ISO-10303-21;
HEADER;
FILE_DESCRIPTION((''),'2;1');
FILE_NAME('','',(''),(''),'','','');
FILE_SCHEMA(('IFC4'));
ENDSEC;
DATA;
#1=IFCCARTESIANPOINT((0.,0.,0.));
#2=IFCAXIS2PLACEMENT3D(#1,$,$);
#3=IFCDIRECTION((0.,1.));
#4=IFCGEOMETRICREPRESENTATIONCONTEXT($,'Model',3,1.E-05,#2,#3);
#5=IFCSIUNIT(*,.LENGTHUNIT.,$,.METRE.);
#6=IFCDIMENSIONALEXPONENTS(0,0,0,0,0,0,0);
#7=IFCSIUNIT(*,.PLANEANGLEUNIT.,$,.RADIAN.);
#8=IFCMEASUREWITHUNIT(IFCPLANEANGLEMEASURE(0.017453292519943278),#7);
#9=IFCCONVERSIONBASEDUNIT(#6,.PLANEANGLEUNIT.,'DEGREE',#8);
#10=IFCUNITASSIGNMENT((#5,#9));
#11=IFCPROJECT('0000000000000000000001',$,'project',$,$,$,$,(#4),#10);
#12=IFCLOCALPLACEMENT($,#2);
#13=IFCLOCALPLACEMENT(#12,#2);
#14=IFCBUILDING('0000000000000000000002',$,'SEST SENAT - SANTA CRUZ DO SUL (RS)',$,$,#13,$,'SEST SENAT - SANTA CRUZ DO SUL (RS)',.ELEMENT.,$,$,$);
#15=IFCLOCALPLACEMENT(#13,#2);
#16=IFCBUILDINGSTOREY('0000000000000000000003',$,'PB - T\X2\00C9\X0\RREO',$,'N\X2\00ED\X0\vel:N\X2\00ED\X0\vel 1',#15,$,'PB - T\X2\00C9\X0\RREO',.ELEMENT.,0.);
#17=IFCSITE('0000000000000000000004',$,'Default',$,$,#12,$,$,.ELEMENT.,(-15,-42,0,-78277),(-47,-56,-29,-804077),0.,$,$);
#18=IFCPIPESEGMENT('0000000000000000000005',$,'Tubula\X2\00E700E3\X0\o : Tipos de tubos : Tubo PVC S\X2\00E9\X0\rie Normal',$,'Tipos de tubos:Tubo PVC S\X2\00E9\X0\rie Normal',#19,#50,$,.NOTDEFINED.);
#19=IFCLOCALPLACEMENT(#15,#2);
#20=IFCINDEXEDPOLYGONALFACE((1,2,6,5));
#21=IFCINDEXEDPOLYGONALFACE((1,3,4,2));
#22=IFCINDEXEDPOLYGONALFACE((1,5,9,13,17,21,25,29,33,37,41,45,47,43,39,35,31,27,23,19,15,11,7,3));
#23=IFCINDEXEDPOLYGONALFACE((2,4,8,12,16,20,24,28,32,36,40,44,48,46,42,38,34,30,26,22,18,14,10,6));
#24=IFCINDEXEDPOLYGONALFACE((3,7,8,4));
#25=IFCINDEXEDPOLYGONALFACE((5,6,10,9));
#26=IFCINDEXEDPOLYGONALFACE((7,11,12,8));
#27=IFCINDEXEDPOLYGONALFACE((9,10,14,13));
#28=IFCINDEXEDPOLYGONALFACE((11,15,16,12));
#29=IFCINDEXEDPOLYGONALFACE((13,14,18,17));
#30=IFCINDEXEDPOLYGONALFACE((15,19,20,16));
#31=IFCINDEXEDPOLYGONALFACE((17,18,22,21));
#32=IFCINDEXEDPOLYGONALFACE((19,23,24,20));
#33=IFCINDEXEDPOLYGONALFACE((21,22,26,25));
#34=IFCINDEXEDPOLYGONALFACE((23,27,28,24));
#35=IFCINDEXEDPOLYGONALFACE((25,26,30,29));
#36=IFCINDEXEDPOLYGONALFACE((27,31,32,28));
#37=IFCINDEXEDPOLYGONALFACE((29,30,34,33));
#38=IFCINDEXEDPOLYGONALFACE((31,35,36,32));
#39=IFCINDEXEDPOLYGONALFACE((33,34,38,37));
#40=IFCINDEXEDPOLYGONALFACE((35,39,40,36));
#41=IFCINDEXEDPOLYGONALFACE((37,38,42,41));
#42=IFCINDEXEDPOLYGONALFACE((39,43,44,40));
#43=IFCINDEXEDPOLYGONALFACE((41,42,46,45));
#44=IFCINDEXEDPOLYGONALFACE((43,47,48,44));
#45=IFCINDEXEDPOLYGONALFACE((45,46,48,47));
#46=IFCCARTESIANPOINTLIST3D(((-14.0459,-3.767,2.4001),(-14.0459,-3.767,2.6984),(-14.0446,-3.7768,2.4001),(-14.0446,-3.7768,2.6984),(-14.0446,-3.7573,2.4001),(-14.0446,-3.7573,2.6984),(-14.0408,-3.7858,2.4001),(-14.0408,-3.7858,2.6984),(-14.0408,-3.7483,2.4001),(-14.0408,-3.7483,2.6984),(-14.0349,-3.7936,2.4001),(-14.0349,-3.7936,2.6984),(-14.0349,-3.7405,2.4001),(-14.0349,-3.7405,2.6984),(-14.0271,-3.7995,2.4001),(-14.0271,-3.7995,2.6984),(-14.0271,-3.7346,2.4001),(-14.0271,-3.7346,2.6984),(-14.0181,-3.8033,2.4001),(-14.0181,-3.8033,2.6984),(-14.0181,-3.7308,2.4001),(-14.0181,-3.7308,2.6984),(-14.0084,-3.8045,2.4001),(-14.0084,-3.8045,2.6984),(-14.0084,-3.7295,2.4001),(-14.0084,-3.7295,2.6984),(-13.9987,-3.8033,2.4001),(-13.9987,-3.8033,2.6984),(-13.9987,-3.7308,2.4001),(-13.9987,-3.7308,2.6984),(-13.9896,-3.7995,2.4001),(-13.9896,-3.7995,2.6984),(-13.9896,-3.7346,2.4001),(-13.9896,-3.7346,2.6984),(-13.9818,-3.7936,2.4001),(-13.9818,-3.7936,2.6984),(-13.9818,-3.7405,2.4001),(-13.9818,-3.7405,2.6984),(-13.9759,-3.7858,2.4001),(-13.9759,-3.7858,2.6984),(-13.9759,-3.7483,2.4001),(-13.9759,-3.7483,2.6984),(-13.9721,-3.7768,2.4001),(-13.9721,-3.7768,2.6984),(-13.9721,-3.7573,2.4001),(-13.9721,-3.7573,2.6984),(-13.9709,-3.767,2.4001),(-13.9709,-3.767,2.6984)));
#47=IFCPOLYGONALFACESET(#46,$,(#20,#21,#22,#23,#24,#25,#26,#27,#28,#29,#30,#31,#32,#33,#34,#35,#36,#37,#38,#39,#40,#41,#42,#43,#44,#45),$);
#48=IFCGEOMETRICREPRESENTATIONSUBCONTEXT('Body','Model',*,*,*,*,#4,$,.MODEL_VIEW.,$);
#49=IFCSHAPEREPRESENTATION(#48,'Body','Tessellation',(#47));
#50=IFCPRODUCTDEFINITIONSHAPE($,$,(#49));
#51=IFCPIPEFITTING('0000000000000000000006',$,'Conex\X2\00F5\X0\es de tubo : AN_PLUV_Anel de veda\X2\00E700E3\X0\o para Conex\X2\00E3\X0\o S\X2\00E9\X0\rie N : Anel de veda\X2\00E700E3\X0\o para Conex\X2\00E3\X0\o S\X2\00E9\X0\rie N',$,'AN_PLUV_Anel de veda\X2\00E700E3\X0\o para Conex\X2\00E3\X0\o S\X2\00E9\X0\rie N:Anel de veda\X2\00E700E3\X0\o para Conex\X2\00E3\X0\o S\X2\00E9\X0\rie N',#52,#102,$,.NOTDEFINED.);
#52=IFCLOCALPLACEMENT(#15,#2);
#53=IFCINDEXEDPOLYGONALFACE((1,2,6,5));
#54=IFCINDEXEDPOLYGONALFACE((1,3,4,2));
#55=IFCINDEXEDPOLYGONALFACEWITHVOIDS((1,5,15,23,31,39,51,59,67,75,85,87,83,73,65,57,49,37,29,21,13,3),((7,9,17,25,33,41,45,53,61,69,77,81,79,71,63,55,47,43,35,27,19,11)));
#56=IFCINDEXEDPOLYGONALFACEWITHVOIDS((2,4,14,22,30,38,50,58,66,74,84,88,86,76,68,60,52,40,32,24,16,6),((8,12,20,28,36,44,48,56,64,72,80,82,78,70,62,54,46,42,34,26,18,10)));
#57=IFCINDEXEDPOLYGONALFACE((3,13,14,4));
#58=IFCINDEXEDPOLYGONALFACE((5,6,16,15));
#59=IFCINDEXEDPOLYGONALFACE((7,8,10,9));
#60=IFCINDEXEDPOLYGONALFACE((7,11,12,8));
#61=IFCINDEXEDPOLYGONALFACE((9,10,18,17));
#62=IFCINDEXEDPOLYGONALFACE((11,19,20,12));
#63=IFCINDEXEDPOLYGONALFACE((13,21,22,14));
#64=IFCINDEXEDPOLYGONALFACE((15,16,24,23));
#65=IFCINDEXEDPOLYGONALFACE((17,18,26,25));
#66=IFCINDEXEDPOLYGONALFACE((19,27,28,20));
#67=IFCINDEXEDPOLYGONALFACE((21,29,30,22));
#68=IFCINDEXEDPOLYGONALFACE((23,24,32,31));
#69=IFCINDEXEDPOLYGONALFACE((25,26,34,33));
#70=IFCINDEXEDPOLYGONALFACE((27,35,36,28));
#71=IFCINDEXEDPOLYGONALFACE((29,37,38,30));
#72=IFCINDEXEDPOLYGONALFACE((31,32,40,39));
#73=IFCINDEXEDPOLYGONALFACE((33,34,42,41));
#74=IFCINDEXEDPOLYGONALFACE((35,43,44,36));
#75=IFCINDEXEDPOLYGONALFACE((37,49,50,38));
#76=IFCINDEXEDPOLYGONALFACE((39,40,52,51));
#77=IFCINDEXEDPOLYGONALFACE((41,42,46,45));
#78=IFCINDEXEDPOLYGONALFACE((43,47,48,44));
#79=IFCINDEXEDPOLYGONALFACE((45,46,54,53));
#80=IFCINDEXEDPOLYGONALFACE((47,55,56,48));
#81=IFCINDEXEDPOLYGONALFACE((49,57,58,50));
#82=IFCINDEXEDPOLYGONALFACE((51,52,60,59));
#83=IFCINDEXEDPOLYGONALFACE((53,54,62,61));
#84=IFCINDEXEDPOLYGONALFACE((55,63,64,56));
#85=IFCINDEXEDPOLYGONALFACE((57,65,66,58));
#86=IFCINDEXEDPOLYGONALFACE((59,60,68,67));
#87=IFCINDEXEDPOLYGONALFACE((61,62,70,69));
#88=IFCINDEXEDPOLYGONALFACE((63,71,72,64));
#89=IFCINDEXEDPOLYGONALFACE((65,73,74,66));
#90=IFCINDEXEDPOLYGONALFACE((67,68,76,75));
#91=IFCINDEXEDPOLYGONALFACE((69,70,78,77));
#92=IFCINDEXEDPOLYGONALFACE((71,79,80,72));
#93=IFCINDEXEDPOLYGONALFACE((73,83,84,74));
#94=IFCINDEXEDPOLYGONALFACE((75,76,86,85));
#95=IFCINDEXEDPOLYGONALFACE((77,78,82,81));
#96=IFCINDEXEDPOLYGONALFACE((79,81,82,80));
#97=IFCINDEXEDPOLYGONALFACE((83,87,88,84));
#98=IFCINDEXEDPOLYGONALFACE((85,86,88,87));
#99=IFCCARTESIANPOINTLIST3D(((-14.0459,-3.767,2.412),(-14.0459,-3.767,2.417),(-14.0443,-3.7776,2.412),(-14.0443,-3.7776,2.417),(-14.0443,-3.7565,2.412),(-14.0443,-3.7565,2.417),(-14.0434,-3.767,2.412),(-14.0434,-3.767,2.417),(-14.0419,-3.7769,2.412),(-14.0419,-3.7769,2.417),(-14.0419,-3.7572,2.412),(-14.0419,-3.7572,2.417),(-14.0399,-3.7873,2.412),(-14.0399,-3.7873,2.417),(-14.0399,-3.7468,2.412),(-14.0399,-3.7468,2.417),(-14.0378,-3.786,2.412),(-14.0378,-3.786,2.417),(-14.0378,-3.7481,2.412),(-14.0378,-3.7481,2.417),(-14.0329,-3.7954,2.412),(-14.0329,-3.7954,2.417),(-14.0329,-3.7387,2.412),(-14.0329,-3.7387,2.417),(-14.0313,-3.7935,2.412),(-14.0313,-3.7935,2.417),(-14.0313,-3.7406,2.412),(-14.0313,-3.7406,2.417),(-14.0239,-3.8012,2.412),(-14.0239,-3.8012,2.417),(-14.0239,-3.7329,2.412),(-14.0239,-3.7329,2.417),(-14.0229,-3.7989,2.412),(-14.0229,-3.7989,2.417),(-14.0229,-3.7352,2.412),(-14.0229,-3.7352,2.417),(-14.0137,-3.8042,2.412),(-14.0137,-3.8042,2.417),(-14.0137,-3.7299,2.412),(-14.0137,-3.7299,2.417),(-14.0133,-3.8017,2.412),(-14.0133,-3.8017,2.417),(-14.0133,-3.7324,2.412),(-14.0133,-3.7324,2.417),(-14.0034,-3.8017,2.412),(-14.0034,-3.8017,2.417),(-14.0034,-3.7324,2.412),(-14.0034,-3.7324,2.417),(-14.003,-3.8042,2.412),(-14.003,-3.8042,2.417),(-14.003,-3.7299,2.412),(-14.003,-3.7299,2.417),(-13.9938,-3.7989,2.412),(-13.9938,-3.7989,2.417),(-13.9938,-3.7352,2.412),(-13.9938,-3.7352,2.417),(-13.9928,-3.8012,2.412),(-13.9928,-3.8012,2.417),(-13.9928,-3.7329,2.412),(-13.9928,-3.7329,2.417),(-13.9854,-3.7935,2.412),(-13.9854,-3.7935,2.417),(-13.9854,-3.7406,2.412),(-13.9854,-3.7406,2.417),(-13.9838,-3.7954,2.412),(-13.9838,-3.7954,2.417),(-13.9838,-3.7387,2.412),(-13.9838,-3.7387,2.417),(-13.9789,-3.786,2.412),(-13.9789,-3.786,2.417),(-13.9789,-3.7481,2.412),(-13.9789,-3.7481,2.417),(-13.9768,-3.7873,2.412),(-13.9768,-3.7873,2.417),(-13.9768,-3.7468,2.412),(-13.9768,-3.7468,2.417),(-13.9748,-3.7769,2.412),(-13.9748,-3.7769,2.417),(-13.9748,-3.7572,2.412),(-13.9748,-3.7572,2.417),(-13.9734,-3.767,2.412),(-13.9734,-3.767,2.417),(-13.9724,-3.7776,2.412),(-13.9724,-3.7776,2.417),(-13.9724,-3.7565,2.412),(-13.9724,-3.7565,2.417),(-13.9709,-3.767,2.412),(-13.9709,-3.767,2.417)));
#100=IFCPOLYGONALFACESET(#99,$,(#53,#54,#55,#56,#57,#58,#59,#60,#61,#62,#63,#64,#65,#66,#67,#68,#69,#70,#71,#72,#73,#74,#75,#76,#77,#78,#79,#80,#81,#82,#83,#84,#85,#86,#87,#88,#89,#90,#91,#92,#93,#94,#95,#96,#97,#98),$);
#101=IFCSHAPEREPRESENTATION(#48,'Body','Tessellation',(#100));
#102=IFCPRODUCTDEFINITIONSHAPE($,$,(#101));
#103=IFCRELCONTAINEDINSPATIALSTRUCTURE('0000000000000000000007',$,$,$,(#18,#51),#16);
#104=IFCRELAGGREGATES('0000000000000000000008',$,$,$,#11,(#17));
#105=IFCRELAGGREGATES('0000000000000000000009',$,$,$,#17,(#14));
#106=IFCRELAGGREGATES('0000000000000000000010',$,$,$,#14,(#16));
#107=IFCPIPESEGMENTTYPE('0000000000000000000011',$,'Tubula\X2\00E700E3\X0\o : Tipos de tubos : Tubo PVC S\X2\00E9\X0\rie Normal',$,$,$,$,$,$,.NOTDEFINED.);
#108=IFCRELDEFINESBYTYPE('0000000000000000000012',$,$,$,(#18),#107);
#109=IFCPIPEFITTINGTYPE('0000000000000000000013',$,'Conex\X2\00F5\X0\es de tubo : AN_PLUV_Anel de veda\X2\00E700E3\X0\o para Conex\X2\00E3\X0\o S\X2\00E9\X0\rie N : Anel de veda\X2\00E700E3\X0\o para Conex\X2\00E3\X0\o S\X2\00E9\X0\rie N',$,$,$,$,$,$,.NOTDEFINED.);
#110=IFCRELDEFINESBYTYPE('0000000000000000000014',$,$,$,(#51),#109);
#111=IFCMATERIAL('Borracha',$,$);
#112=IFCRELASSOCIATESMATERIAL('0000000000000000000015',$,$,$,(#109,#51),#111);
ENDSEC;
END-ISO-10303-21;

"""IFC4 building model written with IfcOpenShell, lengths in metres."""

from ifc_helpers import new_model, entity, si_unit, converted_unit, direction, frame, origin, place, context, subcontext, project, spatial, arc, indexed_curve, outline, extrude, source, transform, mapped, material, type_object, type_shapes, element, save


model = new_model("IFC4")

# Units and contexts
model_context = context("Model", 3, precision=1e-05, world=origin(), true_north=direction((0.0, 1.0)))
body_context = subcontext(model_context, "Body", "Model", "MODEL_VIEW")
ifc_project = project(units=[si_unit("LENGTHUNIT", "METRE"), converted_unit("PLANEANGLEUNIT", "DEGREE", entity("IfcPlaneAngleMeasure", 0.017453292519943278), si_unit("PLANEANGLEUNIT", "RADIAN"), dimensions=[0, 0, 0, 0, 0, 0, 0])], contexts=[model_context])

# Site, building, storey
site_placement = place(None, origin())
site = spatial("IfcSite", under=ifc_project, at=site_placement, Name="Default", CompositionType="ELEMENT", RefLatitude=(-15, -42, 0, -78277), RefLongitude=(-47, -56, -29, -804077), RefElevation=0.0)
building_placement = place(site_placement, origin())
building = spatial("IfcBuilding", under=site, at=building_placement, Name="SEST SENAT - SANTA CRUZ DO SUL (RS)", LongName="SEST SENAT - SANTA CRUZ DO SUL (RS)", CompositionType="ELEMENT")
storey_placement = place(building_placement, origin())
storey = spatial("IfcBuildingStorey", under=building, at=storey_placement, Name="PB - TÉRREO", ObjectType="Nível:Nível 1", LongName="PB - TÉRREO", CompositionType="ELEMENT", Elevation=0.0)

# Pipe segment
pipe_segment_type_1 = type_object("IfcPipeSegmentType", Name="Tubulação : Tipos de tubos : Tubo PVC Série Normal", PredefinedType="NOTDEFINED")
pipe_segment_1_placement = place(storey_placement, frame((-14.0475, -3.8061, 2.4001)))
element("IfcPipeSegment", 1, at=pipe_segment_1_placement, inside=storey, type_object=pipe_segment_type_1, Name="Tubulação : Tipos de tubos : Tubo PVC Série Normal", ObjectType="Tipos de tubos:Tubo PVC Série Normal", PredefinedType="NOTDEFINED", context=body_context, shape_type="SweptSolid", body=[
    extrude(outline(indexed_curve([(0.0375, 0.0), (0.0265, 0.0265), (0.0, 0.0375), (-0.0265, 0.0265), (-0.0375, 0.0), (-0.0265, -0.0265), (0.0, -0.0375), (0.0265, -0.0265)], segments=[arc(1, 2, 3), arc(3, 4, 5), arc(5, 6, 7), arc(7, 8, 1)], self_intersect=False)), frame((0.0391, 0.0391, 0.0), z_axis=(0.0, 0.0, 1.0), x_axis=(-1.0, 0.0, 0.0)), (0.0, 0.0, 1.0), 0.2983),
])

# Pipe fitting
ifc_material = material(Name="Borracha")
pipe_fitting_type = type_object("IfcPipeFittingType", Name="Conexões de tubo : AN_PLUV_Anel de vedação para Conexão Série N : Anel de vedação para Conexão Série N", PredefinedType="NOTDEFINED", material=ifc_material)
shared_shape = source(origin(), body_context, "Body", "SweptSolid", [
    extrude(outline(indexed_curve([(-0.0375, 0.0), (0.0, -0.0375), (0.0375, 0.0), (0.0, 0.0375)], segments=[arc(1, 2, 3), arc(3, 4, 1)], self_intersect=False), holes=[indexed_curve([(-0.035, 0.0), (0.0, 0.035), (0.035, 0.0), (0.0, -0.035)], segments=[arc(1, 2, 3), arc(3, 4, 1)], self_intersect=False)]), frame((0.0, 0.0, -0.005)), (0.0, 0.0, 1.0), 0.005),
])
type_shapes(pipe_fitting_type, [shared_shape])
pipe_fitting_placement = place(storey_placement, frame((-14.0084, -3.767, 2.412), z_axis=(0.0, 0.0, -1.0), x_axis=(-1.0, 0.0, 0.0)))
element("IfcPipeFitting", 2, at=pipe_fitting_placement, inside=storey, type_object=pipe_fitting_type, material=ifc_material, Name="Conexões de tubo : AN_PLUV_Anel de vedação para Conexão Série N : Anel de vedação para Conexão Série N", ObjectType="AN_PLUV_Anel de vedação para Conexão Série N:Anel de vedação para Conexão Série N", PredefinedType="NOTDEFINED", context=body_context, shape_type="MappedRepresentation", body=[
    mapped(shared_shape, transform((0.0, 0.0, 0.0), scale=1.0)),
])

save(model, "model.ifc")
